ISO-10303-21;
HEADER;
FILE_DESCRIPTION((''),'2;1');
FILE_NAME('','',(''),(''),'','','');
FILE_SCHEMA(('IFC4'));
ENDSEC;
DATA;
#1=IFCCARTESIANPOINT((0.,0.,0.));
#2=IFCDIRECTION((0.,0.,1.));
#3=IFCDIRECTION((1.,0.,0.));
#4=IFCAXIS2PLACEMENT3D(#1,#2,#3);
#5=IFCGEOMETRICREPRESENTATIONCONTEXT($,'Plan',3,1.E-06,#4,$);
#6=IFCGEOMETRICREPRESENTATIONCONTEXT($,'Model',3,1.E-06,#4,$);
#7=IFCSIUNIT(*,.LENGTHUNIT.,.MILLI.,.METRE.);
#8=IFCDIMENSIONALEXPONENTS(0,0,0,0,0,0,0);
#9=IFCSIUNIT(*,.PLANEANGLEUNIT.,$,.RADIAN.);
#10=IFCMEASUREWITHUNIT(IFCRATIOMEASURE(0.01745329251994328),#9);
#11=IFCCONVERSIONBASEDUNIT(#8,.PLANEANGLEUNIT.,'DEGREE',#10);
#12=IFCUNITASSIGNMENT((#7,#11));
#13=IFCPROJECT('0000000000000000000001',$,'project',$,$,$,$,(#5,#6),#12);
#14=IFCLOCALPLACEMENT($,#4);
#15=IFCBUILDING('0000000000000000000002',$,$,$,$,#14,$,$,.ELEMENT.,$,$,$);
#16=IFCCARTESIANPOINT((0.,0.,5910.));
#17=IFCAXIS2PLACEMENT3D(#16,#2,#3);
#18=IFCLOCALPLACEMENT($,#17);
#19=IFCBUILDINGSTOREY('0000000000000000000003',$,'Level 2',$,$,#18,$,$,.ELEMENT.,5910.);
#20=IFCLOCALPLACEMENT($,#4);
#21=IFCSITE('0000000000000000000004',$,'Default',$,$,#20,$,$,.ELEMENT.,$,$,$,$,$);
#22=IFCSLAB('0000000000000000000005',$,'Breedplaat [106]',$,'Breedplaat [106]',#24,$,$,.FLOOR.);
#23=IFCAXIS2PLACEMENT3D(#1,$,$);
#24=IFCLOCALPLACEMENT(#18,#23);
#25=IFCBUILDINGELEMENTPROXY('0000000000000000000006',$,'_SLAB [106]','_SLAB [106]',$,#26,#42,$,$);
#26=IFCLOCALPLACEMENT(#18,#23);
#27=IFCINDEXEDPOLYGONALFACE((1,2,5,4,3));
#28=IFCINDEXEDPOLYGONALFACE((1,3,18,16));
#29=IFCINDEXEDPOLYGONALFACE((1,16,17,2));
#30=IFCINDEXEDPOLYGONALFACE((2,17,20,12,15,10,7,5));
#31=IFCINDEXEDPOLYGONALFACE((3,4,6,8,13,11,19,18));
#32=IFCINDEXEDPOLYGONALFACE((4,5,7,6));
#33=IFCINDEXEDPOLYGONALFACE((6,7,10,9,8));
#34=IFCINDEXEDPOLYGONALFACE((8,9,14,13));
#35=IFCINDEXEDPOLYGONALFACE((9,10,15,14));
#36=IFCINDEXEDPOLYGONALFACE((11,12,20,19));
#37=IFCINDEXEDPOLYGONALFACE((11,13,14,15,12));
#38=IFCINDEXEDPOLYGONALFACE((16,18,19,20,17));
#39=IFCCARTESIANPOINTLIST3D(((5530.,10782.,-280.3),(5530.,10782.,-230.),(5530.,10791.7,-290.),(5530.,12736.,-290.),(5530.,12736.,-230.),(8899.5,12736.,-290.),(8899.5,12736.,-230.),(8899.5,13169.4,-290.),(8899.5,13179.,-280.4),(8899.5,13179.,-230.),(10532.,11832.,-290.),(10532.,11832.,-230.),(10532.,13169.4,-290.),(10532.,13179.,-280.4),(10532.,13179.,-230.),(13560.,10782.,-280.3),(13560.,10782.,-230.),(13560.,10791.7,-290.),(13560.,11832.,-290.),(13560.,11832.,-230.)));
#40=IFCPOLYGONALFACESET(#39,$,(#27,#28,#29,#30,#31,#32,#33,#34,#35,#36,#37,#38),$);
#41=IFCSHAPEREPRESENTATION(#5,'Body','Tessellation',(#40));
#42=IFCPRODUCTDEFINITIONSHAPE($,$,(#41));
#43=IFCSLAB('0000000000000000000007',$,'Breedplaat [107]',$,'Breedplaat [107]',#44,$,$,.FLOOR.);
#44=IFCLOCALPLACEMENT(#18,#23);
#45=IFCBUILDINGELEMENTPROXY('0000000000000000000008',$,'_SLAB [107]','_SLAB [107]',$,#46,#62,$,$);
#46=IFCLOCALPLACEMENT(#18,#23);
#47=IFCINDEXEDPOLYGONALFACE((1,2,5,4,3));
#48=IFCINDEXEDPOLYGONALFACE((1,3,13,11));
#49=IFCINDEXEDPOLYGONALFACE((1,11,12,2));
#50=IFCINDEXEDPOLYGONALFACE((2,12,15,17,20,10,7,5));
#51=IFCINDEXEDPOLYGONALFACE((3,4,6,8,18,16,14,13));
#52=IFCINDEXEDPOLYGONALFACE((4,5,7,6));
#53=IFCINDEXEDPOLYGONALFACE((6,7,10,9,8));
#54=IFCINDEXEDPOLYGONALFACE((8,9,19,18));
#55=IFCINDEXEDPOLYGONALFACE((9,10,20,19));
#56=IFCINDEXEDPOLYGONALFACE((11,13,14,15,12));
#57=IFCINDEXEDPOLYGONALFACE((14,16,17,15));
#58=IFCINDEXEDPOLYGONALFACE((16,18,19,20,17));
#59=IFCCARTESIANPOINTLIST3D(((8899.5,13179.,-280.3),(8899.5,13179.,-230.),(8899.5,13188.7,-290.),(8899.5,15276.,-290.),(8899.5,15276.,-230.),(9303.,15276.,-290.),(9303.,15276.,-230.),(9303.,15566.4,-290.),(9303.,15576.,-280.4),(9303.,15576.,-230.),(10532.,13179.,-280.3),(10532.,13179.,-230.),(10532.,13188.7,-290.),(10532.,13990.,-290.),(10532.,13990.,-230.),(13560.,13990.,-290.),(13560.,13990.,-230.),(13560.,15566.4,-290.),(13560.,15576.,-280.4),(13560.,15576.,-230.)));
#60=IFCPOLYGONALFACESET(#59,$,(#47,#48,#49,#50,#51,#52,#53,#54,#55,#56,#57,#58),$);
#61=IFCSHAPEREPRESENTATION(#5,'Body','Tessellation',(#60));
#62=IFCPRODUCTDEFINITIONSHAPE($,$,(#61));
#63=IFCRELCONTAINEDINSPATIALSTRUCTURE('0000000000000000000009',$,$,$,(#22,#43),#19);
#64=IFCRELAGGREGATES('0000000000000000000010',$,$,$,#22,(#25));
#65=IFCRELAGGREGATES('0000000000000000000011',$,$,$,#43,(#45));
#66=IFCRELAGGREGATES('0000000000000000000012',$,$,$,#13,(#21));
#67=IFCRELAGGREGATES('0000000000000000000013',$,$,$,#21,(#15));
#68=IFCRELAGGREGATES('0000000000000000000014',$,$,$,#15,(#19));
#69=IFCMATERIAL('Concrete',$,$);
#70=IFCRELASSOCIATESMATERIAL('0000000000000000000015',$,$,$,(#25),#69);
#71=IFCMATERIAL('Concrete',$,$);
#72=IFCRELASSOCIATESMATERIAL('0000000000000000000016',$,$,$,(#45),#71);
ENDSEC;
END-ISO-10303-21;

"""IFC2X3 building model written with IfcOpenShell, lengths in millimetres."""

from ifc_helpers import new_model, entity, si_unit, converted_unit, frame, origin_with_axes, place, context, project, spatial, polyline, outline, extrude, material, element, aggregate, save


model = new_model("IFC2X3")

# Units and contexts
plan_context = context("Plan", 3, precision=1e-06, world=origin_with_axes())
model_context = context("Model", 3, precision=1e-06, world=origin_with_axes())
ifc_project = project(units=[si_unit("LENGTHUNIT", "METRE", prefix="MILLI"), converted_unit("PLANEANGLEUNIT", "DEGREE", entity("IfcRatioMeasure", 0.01745329251994328), si_unit("PLANEANGLEUNIT", "RADIAN"), dimensions=[0, 0, 0, 0, 0, 0, 0])], contexts=[plan_context, model_context])

# Site, building, storey
site_placement = place(None, origin_with_axes())
site = spatial("IfcSite", under=ifc_project, at=site_placement, Name="Default", CompositionType="ELEMENT")
building_placement = place(None, origin_with_axes())
building = spatial("IfcBuilding", under=site, at=building_placement, CompositionType="ELEMENT")
storey_placement = place(None, frame((0.0, 0.0, 5910.0), z_axis=(0.0, 0.0, 1.0), x_axis=(1.0, 0.0, 0.0)))
storey = spatial("IfcBuildingStorey", under=building, at=storey_placement, Name="Level 2", CompositionType="ELEMENT", Elevation=5910.0)

# Slabs, building element proxies, openings
slab_1_placement = place(None, frame((5530.0, 10782.0, 5620.0), z_axis=(0.0, 0.0, 1.0), x_axis=(1.0, 0.0, 0.0)))
slab_1 = element("IfcSlab", 1, at=slab_1_placement, inside=storey, Name="Breedplaat [106]", ObjectType="Breedplaat [106]", PredefinedType="FLOOR")
ifc_material_1 = material(Name="Concrete")
proxy_1_placement = place(slab_1_placement, origin_with_axes())
proxy_1 = element("IfcBuildingElementProxy", 2, at=proxy_1_placement, material=ifc_material_1, Name="_SLAB [106]", Description="_SLAB [106]", context=plan_context, shape_type="SweptSolid", body=[
    extrude(outline(polyline([(3369.5, 2397.0), (3369.5, 1954.0), (0.0, 1954.0), (0.0, 0.0), (8030.0, 0.0), (8030.0, 1050.0), (5002.0, 1050.0), (5002.0, 2397.0), (3369.5, 2397.0)])), origin_with_axes(), (0.0, 0.0, 1.0), 60.0),
])
opening_1_placement = place(None, frame((5530.0, 10782.0, 5620.0), z_axis=(0.0, 0.0, 1.0), x_axis=(1.0, 0.0, 0.0)))
element("IfcOpeningElement", 3, at=opening_1_placement, cuts=proxy_1, ObjectType="Opening", context=plan_context, shape_type="SweptSolid", body=[
    extrude(outline(polyline([(-0.1, -0.1), (-0.1, 10.0), (10.0, -0.1), (-0.1, -0.1)])), frame((-1.2, -0.1, -0.1), z_axis=(1.0, 0.0, 0.0), x_axis=(0.0, 1.0, 0.0)), (0.0, 0.0, 1.0), 8032.2),
])
opening_2_placement = place(None, frame((5530.0, 10782.0, 5620.0), z_axis=(0.0, 0.0, 1.0), x_axis=(1.0, 0.0, 0.0)))
element("IfcOpeningElement", 4, at=opening_2_placement, cuts=proxy_1, ObjectType="Opening", context=plan_context, shape_type="SweptSolid", body=[
    extrude(outline(polyline([(-0.1, -0.1), (-0.1, 10.0), (10.0, -0.1), (-0.1, -0.1)])), frame((5003.2, 2397.2, -0.1), z_axis=(-1.0, 0.0, 0.0), x_axis=(0.0, -1.0, 0.0)), (0.0, 0.0, 1.0), 1634.7),
])
aggregate(slab_1, [proxy_1])
slab_2_placement = place(None, frame((8899.5, 13179.0, 5620.0), z_axis=(0.0, 0.0, 1.0), x_axis=(1.0, 0.0, 0.0)))
slab_2 = element("IfcSlab", 5, at=slab_2_placement, inside=storey, Name="Breedplaat [107]", ObjectType="Breedplaat [107]", PredefinedType="FLOOR")
ifc_material_2 = material(Name="Concrete")
proxy_2_placement = place(slab_2_placement, origin_with_axes())
proxy_2 = element("IfcBuildingElementProxy", 6, at=proxy_2_placement, material=ifc_material_2, Name="_SLAB [107]", Description="_SLAB [107]", context=plan_context, shape_type="SweptSolid", body=[
    extrude(outline(polyline([(1632.5, 0.0), (1632.5, 811.0), (4660.6, 811.0), (4660.6, 2397.0), (403.6, 2397.0), (403.6, 2097.0), (0.0, 2097.0), (0.0, 0.0), (1632.5, 0.0)])), origin_with_axes(), (0.0, 0.0, 1.0), 60.0),
])
opening_3_placement = place(None, frame((8899.5, 13179.0, 5620.0), z_axis=(0.0, 0.0, 1.0), x_axis=(1.0, 0.0, 0.0)))
element("IfcOpeningElement", 7, at=opening_3_placement, cuts=proxy_2, ObjectType="Opening", context=plan_context, shape_type="SweptSolid", body=[
    extrude(outline(polyline([(-0.1, -0.1), (-0.1, 10.0), (10.0, -0.1), (-0.1, -0.1)])), frame((-1.2, -0.1, -0.1), z_axis=(1.0, 0.0, 0.0), x_axis=(0.0, 1.0, 0.0)), (0.0, 0.0, 1.0), 1634.8),
])
opening_4_placement = place(None, frame((8899.5, 13179.0, 5620.0), z_axis=(0.0, 0.0, 1.0), x_axis=(1.0, 0.0, 0.0)))
element("IfcOpeningElement", 8, at=opening_4_placement, cuts=proxy_2, ObjectType="Opening", context=plan_context, shape_type="SweptSolid", body=[
    extrude(outline(polyline([(-0.1, -0.1), (-0.1, 10.0), (10.0, -0.1), (-0.1, -0.1)])), frame((4661.8, 2397.2, -0.1), z_axis=(-1.0, 0.0, 0.0), x_axis=(0.0, -1.0, 0.0)), (0.0, 0.0, 1.0), 4259.2),
])
aggregate(slab_2, [proxy_2])

save(model, "model.ifc")
